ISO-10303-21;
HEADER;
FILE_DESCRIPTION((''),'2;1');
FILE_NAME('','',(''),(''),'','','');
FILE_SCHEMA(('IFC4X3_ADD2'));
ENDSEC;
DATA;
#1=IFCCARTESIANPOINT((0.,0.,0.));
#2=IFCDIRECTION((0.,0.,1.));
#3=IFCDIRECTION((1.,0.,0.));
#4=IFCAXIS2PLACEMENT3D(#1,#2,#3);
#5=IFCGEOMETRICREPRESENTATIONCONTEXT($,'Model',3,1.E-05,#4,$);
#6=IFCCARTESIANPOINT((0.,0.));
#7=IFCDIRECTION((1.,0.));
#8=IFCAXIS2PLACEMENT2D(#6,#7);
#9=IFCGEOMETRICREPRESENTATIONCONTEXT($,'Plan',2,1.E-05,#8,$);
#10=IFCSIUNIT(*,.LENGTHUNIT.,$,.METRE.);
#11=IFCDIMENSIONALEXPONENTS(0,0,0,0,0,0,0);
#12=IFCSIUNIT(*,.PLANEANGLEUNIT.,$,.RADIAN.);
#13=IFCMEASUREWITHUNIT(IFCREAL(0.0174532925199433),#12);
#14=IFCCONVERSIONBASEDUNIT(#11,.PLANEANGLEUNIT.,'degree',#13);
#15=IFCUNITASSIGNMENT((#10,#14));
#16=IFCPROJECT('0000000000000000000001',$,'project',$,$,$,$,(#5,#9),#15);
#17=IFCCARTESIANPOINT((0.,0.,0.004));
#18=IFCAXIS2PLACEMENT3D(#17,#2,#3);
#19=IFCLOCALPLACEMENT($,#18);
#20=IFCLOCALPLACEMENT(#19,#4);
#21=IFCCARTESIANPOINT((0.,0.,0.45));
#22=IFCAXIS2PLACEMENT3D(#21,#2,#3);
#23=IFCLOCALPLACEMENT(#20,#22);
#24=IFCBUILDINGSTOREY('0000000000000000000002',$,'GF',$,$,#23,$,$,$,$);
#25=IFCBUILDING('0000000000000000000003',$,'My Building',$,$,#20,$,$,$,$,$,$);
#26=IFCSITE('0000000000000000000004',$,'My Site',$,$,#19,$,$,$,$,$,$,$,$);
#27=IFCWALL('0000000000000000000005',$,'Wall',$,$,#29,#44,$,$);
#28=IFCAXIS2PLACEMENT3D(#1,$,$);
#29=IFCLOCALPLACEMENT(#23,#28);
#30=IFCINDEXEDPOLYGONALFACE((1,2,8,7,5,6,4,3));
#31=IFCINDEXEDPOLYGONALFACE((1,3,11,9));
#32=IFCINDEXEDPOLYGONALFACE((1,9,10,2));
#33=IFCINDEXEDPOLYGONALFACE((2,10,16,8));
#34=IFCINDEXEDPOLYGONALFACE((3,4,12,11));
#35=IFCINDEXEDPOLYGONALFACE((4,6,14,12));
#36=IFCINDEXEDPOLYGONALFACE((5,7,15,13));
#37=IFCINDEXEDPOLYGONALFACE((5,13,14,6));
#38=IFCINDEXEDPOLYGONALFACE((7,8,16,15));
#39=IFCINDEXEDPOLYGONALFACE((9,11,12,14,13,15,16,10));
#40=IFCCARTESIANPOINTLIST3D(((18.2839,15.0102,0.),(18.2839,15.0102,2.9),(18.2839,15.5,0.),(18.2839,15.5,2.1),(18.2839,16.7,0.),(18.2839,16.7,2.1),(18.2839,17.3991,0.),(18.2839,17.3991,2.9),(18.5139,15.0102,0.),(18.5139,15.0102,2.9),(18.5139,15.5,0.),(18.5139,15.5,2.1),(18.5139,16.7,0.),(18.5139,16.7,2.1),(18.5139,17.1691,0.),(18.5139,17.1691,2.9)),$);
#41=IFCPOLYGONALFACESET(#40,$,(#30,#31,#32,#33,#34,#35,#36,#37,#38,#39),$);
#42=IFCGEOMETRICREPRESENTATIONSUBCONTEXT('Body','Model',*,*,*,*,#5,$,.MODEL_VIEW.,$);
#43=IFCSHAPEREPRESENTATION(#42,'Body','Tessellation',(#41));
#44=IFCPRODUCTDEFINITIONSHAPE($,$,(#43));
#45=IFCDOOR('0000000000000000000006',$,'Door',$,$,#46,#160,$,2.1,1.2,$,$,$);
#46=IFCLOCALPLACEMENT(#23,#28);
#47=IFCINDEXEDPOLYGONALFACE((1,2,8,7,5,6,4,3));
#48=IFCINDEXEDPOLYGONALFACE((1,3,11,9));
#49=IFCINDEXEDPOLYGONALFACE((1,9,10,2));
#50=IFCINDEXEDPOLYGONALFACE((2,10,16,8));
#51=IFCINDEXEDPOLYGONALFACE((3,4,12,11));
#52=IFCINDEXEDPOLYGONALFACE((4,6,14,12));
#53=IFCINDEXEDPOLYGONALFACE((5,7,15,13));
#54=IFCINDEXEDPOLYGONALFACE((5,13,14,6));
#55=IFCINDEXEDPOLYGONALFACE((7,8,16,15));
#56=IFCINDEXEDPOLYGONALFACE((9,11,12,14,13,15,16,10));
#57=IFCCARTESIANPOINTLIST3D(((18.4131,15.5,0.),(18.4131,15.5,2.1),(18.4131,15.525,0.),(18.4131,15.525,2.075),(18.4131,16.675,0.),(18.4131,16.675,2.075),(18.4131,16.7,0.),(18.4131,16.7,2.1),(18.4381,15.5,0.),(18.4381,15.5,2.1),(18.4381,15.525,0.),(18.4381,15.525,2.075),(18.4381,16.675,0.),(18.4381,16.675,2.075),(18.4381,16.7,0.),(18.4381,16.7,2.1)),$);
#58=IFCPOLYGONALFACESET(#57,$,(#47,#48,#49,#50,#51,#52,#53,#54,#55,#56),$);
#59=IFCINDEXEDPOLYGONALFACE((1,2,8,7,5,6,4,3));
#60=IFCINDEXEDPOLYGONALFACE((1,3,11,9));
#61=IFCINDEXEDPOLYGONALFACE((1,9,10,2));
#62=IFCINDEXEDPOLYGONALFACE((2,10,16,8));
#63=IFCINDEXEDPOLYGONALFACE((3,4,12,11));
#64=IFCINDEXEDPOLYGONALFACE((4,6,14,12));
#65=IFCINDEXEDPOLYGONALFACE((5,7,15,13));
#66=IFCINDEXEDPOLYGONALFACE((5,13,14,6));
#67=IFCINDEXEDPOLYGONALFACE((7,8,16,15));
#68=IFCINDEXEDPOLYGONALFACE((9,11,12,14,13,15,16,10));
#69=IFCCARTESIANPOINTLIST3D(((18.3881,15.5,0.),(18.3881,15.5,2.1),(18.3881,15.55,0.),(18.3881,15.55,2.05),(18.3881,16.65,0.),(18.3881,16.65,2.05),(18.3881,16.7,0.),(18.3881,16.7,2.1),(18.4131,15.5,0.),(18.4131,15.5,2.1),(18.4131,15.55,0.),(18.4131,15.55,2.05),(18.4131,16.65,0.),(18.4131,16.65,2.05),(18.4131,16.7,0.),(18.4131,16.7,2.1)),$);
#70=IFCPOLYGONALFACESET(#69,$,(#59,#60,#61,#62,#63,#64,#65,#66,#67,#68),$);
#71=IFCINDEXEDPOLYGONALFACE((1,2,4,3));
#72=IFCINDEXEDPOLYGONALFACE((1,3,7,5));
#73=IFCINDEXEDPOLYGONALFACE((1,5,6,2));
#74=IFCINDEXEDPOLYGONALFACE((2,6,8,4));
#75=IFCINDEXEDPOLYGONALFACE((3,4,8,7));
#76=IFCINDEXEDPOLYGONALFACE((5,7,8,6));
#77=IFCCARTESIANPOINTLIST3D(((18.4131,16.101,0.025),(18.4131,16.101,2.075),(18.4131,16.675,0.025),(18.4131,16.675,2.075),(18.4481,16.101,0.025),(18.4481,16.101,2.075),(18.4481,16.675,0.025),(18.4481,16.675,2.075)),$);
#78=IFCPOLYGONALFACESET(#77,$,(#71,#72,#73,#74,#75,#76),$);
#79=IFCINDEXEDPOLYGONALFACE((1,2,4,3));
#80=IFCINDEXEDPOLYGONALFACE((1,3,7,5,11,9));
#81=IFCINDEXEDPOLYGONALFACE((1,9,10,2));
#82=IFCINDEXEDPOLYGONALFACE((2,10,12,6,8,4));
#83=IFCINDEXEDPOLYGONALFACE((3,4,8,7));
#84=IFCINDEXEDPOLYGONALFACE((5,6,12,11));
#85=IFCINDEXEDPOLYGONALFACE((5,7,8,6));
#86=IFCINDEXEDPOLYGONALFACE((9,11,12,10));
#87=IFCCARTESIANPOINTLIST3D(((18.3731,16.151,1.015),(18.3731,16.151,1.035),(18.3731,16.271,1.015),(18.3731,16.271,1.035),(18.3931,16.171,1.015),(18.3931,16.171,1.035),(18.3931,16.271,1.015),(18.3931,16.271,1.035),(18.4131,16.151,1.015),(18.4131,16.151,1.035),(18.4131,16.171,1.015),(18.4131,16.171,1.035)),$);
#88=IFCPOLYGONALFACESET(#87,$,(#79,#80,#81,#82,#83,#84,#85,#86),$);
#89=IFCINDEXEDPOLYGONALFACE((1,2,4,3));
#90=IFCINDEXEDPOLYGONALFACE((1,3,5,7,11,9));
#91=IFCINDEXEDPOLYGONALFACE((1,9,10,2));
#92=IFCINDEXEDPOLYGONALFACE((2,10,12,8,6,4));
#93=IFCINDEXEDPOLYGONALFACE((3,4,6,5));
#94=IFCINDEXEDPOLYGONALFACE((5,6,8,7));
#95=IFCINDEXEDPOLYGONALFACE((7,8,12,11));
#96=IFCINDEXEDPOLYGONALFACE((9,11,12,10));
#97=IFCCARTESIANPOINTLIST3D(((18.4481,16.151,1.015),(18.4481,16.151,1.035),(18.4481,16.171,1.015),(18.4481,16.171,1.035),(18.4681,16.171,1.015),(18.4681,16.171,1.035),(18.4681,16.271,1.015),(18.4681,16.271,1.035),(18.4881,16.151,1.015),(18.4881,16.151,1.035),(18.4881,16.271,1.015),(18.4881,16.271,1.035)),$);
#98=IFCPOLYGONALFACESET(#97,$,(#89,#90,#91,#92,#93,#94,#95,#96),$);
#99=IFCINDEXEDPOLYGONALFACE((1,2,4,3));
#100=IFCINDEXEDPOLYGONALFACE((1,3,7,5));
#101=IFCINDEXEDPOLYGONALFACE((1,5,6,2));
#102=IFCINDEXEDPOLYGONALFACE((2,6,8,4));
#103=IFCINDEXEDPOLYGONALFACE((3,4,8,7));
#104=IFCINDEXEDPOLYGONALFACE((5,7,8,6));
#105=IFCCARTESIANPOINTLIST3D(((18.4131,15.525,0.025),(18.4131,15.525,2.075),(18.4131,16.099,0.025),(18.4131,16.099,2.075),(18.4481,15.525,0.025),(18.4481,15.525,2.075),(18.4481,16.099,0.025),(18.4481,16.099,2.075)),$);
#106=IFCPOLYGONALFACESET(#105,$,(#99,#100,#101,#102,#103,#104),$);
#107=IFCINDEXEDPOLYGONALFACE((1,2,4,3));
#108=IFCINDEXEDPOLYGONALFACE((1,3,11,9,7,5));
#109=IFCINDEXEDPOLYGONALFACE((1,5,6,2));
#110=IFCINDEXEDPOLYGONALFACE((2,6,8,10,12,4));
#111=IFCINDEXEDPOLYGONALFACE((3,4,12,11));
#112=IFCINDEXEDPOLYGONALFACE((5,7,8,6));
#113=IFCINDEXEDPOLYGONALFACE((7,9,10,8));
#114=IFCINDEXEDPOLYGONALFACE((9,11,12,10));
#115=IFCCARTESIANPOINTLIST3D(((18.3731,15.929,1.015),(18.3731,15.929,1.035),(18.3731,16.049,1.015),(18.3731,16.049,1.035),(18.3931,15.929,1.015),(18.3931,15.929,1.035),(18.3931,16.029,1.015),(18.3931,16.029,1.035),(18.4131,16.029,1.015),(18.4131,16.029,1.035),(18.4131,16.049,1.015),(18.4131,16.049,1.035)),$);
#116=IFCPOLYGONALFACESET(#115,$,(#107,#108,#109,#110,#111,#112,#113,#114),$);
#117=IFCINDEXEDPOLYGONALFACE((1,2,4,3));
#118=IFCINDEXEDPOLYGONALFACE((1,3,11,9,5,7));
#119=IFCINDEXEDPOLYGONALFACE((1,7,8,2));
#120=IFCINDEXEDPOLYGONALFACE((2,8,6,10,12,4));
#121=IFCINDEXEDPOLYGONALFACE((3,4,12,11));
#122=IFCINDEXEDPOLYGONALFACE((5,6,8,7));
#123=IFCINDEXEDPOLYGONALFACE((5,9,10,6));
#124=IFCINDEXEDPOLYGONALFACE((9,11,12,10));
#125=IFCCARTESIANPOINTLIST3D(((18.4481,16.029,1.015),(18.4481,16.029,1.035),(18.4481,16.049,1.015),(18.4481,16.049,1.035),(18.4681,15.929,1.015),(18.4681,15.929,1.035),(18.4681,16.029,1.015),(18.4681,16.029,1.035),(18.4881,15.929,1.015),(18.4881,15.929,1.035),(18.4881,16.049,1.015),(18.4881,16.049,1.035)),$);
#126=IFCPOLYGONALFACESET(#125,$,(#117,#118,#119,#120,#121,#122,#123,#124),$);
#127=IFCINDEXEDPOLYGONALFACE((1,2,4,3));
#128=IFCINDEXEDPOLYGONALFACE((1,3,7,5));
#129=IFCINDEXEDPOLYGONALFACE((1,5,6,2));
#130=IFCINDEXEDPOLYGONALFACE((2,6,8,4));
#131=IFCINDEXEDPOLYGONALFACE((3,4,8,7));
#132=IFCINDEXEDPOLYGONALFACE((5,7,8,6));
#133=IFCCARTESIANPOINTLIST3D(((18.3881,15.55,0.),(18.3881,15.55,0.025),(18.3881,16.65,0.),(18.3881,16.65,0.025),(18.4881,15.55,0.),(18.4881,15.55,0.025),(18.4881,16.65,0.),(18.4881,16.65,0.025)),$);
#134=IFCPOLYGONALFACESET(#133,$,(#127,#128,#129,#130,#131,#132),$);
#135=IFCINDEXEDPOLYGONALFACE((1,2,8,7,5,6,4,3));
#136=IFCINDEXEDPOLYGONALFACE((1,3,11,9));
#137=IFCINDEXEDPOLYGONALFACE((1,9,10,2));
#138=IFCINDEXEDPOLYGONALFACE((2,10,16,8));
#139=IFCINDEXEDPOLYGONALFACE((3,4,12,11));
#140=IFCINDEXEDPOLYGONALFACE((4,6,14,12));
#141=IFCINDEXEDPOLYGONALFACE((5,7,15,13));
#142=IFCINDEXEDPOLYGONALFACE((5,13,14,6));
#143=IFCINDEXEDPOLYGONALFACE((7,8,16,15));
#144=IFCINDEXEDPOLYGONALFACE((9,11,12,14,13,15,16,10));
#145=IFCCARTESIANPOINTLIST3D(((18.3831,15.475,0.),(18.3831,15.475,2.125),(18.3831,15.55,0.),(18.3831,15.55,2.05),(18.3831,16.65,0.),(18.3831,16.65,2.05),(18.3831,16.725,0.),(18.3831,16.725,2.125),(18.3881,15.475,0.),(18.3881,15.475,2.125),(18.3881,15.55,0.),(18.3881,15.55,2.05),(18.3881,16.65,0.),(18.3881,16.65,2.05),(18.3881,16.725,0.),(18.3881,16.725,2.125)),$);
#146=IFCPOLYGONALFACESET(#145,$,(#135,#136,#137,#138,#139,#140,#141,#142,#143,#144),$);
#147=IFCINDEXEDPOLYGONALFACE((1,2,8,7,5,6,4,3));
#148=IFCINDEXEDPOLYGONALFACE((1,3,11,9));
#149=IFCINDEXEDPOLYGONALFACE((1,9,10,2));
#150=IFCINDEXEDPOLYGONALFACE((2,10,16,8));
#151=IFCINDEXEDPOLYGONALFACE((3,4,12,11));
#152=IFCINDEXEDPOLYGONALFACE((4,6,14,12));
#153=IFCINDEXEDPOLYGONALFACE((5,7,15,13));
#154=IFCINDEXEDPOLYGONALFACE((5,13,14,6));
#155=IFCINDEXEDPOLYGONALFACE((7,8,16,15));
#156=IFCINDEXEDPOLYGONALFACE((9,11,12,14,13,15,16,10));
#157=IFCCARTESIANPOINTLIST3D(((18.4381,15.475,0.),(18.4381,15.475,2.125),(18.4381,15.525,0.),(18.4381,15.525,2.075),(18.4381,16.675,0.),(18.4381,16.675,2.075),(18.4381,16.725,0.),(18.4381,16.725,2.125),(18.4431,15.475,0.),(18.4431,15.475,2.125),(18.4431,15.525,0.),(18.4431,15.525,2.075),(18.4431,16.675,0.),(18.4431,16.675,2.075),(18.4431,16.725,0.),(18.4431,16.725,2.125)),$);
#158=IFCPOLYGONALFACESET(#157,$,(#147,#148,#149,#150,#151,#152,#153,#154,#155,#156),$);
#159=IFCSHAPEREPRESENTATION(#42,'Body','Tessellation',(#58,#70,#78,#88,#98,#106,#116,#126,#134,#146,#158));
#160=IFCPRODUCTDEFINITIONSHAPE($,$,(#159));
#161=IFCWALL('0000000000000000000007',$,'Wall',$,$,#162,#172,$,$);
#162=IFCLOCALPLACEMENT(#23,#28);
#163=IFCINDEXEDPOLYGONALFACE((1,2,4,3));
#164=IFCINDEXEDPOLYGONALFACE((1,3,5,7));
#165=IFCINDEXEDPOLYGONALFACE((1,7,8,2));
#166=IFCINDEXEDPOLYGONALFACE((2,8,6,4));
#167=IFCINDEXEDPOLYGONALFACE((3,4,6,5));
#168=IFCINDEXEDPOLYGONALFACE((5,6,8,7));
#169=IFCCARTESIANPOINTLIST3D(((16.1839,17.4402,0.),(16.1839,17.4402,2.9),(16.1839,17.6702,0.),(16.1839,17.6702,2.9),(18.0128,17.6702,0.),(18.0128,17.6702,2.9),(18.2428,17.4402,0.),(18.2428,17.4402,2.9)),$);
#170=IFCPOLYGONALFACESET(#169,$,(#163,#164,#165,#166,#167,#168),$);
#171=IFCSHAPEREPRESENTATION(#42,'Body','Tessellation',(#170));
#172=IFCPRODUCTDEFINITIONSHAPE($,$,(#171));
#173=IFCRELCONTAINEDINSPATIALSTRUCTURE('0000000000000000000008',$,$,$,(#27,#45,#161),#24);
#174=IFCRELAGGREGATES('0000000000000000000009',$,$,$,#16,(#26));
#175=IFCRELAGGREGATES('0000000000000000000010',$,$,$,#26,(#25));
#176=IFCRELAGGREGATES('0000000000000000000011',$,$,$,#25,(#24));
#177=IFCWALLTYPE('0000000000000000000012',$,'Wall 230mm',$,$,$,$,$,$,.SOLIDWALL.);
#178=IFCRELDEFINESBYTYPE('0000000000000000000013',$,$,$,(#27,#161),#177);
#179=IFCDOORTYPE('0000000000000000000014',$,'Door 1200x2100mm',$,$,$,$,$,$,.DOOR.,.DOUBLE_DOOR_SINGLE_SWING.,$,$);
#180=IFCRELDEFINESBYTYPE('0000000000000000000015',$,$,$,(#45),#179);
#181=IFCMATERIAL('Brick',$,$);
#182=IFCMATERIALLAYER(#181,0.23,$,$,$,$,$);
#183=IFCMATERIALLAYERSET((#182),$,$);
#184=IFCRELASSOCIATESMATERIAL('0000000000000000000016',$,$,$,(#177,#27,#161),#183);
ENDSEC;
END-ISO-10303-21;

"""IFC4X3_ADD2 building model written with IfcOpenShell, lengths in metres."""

from ifc_helpers import new_model, entity, si_unit, converted_unit, frame, origin_with_axes, origin_2d_with_axis, place, context, subcontext, project, spatial, line, indexed_curve, outline, extrude, clip, halfspace, shape, source, transform, mapped, material, layer, layer_set, layer_usage, type_object, type_shapes, element, fill, save


model = new_model("IFC4X3_ADD2")

# Units and contexts
model_context = context("Model", 3, precision=1e-05, world=origin_with_axes())
plan_context = context("Plan", 2, precision=1e-05, world=origin_2d_with_axis())
body_context_1 = subcontext(model_context, "Body", "Model", "MODEL_VIEW")
body_context_2 = subcontext(plan_context, "Body", "Plan", "PLAN_VIEW")
ifc_project = project(units=[si_unit("LENGTHUNIT", "METRE"), converted_unit("PLANEANGLEUNIT", "degree", entity("IfcReal", 0.0174532925199433), si_unit("PLANEANGLEUNIT", "RADIAN"), dimensions=[0, 0, 0, 0, 0, 0, 0])], contexts=[model_context, plan_context])

# Site, building, storey
site_placement = place(None, frame((0.0, 0.0, 0.004), z_axis=(0.0, 0.0, 1.0), x_axis=(1.0, 0.0, 0.0)))
site = spatial("IfcSite", under=ifc_project, at=site_placement, Name="My Site")
building_placement = place(site_placement, origin_with_axes())
building = spatial("IfcBuilding", under=site, at=building_placement, Name="My Building")
storey_placement = place(building_placement, frame((0.0, 0.0, 0.45), z_axis=(0.0, 0.0, 1.0), x_axis=(1.0, 0.0, 0.0)))
storey = spatial("IfcBuildingStorey", under=building, at=storey_placement, Name="GF")

# Shared definitions
ifc_material_1 = material(Name="Brick")
ifc_layer_1 = layer(ifc_material_1, 0.23)
ifc_layer_set_1 = layer_set([ifc_layer_1])
wall_type = type_object("IfcWallType", Name="Wall 230mm", PredefinedType="SOLIDWALL", material=ifc_layer_set_1)

# Wall, opening, door
ifc_layer_usage_1 = layer_usage(ifc_layer_set_1, "AXIS2", "POSITIVE", 0.0)
wall_1_placement = place(storey_placement, frame((18.5139, 15.0102, 0.0), z_axis=(0.0, 0.0, 1.0), x_axis=(0.000001, 1.0, 0.0)))
wall_1 = element("IfcWall", 1, at=wall_1_placement, inside=storey, type_object=wall_type, material=ifc_layer_usage_1, Name="Wall", context=body_context_1, shape_type="Clipping", body=[
    clip(extrude(outline(indexed_curve([(0.0, 0.0), (0.0, 0.23), (2.3889, 0.23), (2.3889, 0.0), (0.0, 0.0)], self_intersect=False)), origin_with_axes(), (0.0, 0.0, 1.0), 2.9), halfspace(frame((2.1589, 0.0, -0.454), z_axis=(0.689999, -0.689998, 0.0), x_axis=(-0.707106, -0.707107, 0.0)), False)),
])
shared_shape_1 = source(origin_with_axes(), body_context_1, "Body", "SweptSolid", [
    extrude(outline(indexed_curve([(0.0, 0.0), (1.2, 0.0), (1.2, 2.1), (0.0, 2.1)], segments=[line(1, 2, 3, 4, 1)])), frame((0.0, -0.6, 0.0), z_axis=(0.0, -1.0, 0.0), x_axis=(1.0, 0.0, 0.0)), (0.0, 0.0, -1.0), 1.2),
])
opening_1_placement = place(wall_1_placement, frame((0.4898, 0.0, 0.0), z_axis=(0.0, 0.0, 1.0), x_axis=(1.0, 0.0, 0.0)))
opening_1 = element("IfcOpeningElement", 2, at=opening_1_placement, cuts=wall_1, PredefinedType="OPENING", context=body_context_1, shape_type="MappedRepresentation", body=[
    mapped(shared_shape_1, transform((0.0, 0.0, 0.0), x_axis=(1.0, 0.0, 0.0), y_axis=(0.0, 1.0, 0.0), z_axis=(0.0, 0.0, 1.0), scale=1.0)),
])
door_type_1 = type_object("IfcDoorType", Name="Door 1200x2100mm", OperationType="DOUBLE_DOOR_SINGLE_SWING", PredefinedType="DOOR")
shared_shape_2 = source(origin_with_axes(), body_context_1, "Body", "SweptSolid", [
    extrude(outline(indexed_curve([(0.0, 0.0), (0.0, 2.1), (1.2, 2.1), (1.2, 0.0), (1.175, 0.0), (1.175, 2.075), (0.025, 2.075), (0.025, 0.0)], segments=[line(1, 2, 3, 4, 5, 6, 7, 8, 1)])), frame((0.0, 0.025, 0.0), z_axis=(0.0, -1.0, 0.0), x_axis=(1.0, 0.0, 0.0)), (0.0, 0.0, -1.0), 0.025),
    extrude(outline(indexed_curve([(0.0, 0.0), (0.0, 2.1), (1.2, 2.1), (1.2, 0.0), (1.15, 0.0), (1.15, 2.05), (0.05, 2.05), (0.05, 0.0)], segments=[line(1, 2, 3, 4, 5, 6, 7, 8, 1)])), frame((0.0, 0.0, 0.0), z_axis=(0.0, -1.0, 0.0), x_axis=(1.0, 0.0, 0.0)), (0.0, 0.0, -1.0), 0.025),
    extrude(outline(indexed_curve([(0.0, 0.0), (0.574, 0.0), (0.574, 0.035), (0.0, 0.035)], segments=[line(1, 2, 3, 4, 1)])), frame((0.025, 0.025, 0.025), z_axis=(0.0, 0.0, 1.0), x_axis=(1.0, 0.0, 0.0)), (0.0, 0.0, 1.0), 2.05),
    extrude(outline(indexed_curve([(0.0, 0.0), (0.0, -0.04), (-0.12, -0.04), (-0.12, -0.02), (-0.02, -0.02), (-0.02, 0.0)], segments=[line(1, 2, 3, 4, 5, 6, 1)])), frame((0.549, 0.025, 1.015), z_axis=(0.0, 0.0, 1.0), x_axis=(1.0, 0.0, 0.0)), (0.0, 0.0, 1.0), 0.02),
    extrude(outline(indexed_curve([(0.0, 0.0), (0.0, 0.04), (-0.12, 0.04), (-0.12, 0.02), (-0.02, 0.02), (-0.02, 0.0)], segments=[line(1, 2, 3, 4, 5, 6, 1)])), frame((0.549, 0.06, 1.015), z_axis=(0.0, 0.0, 1.0), x_axis=(1.0, 0.0, 0.0)), (0.0, 0.0, 1.0), 0.02),
    extrude(outline(indexed_curve([(0.0, 0.0), (-0.574, 0.0), (-0.574, 0.035), (0.0, 0.035)], segments=[line(1, 2, 3, 4, 1)])), frame((1.175, 0.025, 0.025), z_axis=(0.0, 0.0, 1.0), x_axis=(1.0, 0.0, 0.0)), (0.0, 0.0, 1.0), 2.05),
    extrude(outline(indexed_curve([(0.0, 0.0), (0.0, -0.04), (0.12, -0.04), (0.12, -0.02), (0.02, -0.02), (0.02, 0.0)], segments=[line(1, 2, 3, 4, 5, 6, 1)])), frame((0.651, 0.025, 1.015), z_axis=(0.0, 0.0, 1.0), x_axis=(1.0, 0.0, 0.0)), (0.0, 0.0, 1.0), 0.02),
    extrude(outline(indexed_curve([(0.0, 0.0), (0.0, 0.04), (0.12, 0.04), (0.12, 0.02), (0.02, 0.02), (0.02, 0.0)], segments=[line(1, 2, 3, 4, 5, 6, 1)])), frame((0.651, 0.06, 1.015), z_axis=(0.0, 0.0, 1.0), x_axis=(1.0, 0.0, 0.0)), (0.0, 0.0, 1.0), 0.02),
    extrude(outline(indexed_curve([(0.0, 0.0), (1.1, 0.0), (1.1, 0.1), (0.0, 0.1)], segments=[line(1, 2, 3, 4, 1)])), frame((0.05, 0.0, 0.0), z_axis=(0.0, 0.0, 1.0), x_axis=(1.0, 0.0, 0.0)), (0.0, 0.0, 1.0), 0.025),
    extrude(outline(indexed_curve([(0.0, 0.0), (0.0, 2.125), (1.25, 2.125), (1.25, 0.0), (1.175, 0.0), (1.175, 2.05), (0.075, 2.05), (0.075, 0.0)], segments=[line(1, 2, 3, 4, 5, 6, 7, 8, 1)])), frame((-0.025, -0.005, 0.0), z_axis=(0.0, -1.0, 0.0), x_axis=(1.0, 0.0, 0.0)), (0.0, 0.0, -1.0), 0.005),
    extrude(outline(indexed_curve([(0.0, 0.0), (0.0, 2.125), (1.25, 2.125), (1.25, 0.0), (1.2, 0.0), (1.2, 2.075), (0.05, 2.075), (0.05, 0.0)], segments=[line(1, 2, 3, 4, 5, 6, 7, 8, 1)])), frame((-0.025, 0.05, 0.0), z_axis=(0.0, -1.0, 0.0), x_axis=(1.0, 0.0, 0.0)), (0.0, 0.0, -1.0), 0.005),
])
shared_shape_3 = source(origin_with_axes(), body_context_2, "Body", "Curve2D", [
    entity("IfcIndexedPolyCurve", entity("IfcCartesianPointList2D", [[0.0, 0.0], [0.0, 0.05], [0.025, 0.05], [0.025, 0.025], [0.05, 0.025], [0.05, 0.0]]), [entity("IfcLineIndex", [1, 2, 3, 4, 5, 6, 1])]),
    entity("IfcIndexedPolyCurve", entity("IfcCartesianPointList2D", [[1.2, 0.0], [1.2, 0.05], [1.175, 0.05], [1.175, 0.025], [1.15, 0.025], [1.15, 0.0]]), [entity("IfcLineIndex", [1, 2, 3, 4, 5, 6, 1])]),
    entity("IfcTrimmedCurve", entity("IfcEllipse", entity("IfcAxis2Placement2D", entity("IfcCartesianPoint", [0.06, 0.05]), entity("IfcDirection", [1.0, 0.0])), 0.54, 0.575), [entity("IfcCartesianPoint", [0.6, 0.05])], [entity("IfcCartesianPoint", [0.06, 0.625])], True, "CARTESIAN"),
    entity("IfcIndexedPolyCurve", entity("IfcCartesianPointList2D", [[0.025, 0.05], [0.06, 0.05], [0.06, 0.625], [0.025, 0.625]]), [entity("IfcLineIndex", [1, 2, 3, 4, 1])]),
    entity("IfcTrimmedCurve", entity("IfcEllipse", entity("IfcAxis2Placement2D", entity("IfcCartesianPoint", [1.14, 0.05]), entity("IfcDirection", [1.0, 0.0])), 0.54, 0.575), [entity("IfcCartesianPoint", [1.14, 0.625])], [entity("IfcCartesianPoint", [0.6, 0.05])], True, "CARTESIAN"),
    entity("IfcIndexedPolyCurve", entity("IfcCartesianPointList2D", [[1.175, 0.05], [1.14, 0.05], [1.14, 0.625], [1.175, 0.625]]), [entity("IfcLineIndex", [1, 2, 3, 4, 1])]),
])
type_shapes(door_type_1, [shared_shape_2, shared_shape_3])
door_1_placement = place(opening_1_placement, frame((1.2, 0.1258, 0.0), z_axis=(0.0, 0.0, 1.0), x_axis=(-1.0, 0.0, 0.0)))
door_1 = element("IfcDoor", 3, at=door_1_placement, inside=storey, type_object=door_type_1, Name="Door", OverallHeight=2.1, OverallWidth=1.2, shapes=[
    shape(body_context_1, "Body", "MappedRepresentation", [mapped(shared_shape_2, transform((0.0, 0.0, 0.0), x_axis=(1.0, 0.0, 0.0), y_axis=(0.0, 1.0, 0.0), z_axis=(0.0, 0.0, 1.0), scale=1.0))]),
    shape(body_context_2, "Body", "MappedRepresentation", [mapped(shared_shape_3, transform((0.0, 0.0, 0.0), x_axis=(1.0, 0.0, 0.0), y_axis=(0.0, 1.0, 0.0), z_axis=(0.0, 0.0, 1.0), scale=1.0))]),
])
fill(opening_1, door_1)

# Wall
ifc_layer_usage_2 = layer_usage(ifc_layer_set_1, "AXIS2", "POSITIVE", 0.0)
wall_2_placement = place(storey_placement, frame((18.2428, 17.6702, 0.0), z_axis=(0.0, 0.0, 1.0), x_axis=(-1.0, 0.0, 0.0)))
element("IfcWall", 4, at=wall_2_placement, inside=storey, type_object=wall_type, material=ifc_layer_usage_2, Name="Wall", context=body_context_1, shape_type="Clipping", body=[
    clip(extrude(outline(indexed_curve([(0.0, 0.0), (0.0, 0.23), (2.0589, 0.23), (2.0589, 0.0), (0.0, 0.0)], self_intersect=False)), origin_with_axes(), (0.0, 0.0, 1.0), 2.9), halfspace(frame((0.23, 0.0, -0.454), z_axis=(-0.689999, -0.689999, 0.0), x_axis=(-0.707107, 0.707107, 0.0)), False)),
])

save(model, "model.ifc")
